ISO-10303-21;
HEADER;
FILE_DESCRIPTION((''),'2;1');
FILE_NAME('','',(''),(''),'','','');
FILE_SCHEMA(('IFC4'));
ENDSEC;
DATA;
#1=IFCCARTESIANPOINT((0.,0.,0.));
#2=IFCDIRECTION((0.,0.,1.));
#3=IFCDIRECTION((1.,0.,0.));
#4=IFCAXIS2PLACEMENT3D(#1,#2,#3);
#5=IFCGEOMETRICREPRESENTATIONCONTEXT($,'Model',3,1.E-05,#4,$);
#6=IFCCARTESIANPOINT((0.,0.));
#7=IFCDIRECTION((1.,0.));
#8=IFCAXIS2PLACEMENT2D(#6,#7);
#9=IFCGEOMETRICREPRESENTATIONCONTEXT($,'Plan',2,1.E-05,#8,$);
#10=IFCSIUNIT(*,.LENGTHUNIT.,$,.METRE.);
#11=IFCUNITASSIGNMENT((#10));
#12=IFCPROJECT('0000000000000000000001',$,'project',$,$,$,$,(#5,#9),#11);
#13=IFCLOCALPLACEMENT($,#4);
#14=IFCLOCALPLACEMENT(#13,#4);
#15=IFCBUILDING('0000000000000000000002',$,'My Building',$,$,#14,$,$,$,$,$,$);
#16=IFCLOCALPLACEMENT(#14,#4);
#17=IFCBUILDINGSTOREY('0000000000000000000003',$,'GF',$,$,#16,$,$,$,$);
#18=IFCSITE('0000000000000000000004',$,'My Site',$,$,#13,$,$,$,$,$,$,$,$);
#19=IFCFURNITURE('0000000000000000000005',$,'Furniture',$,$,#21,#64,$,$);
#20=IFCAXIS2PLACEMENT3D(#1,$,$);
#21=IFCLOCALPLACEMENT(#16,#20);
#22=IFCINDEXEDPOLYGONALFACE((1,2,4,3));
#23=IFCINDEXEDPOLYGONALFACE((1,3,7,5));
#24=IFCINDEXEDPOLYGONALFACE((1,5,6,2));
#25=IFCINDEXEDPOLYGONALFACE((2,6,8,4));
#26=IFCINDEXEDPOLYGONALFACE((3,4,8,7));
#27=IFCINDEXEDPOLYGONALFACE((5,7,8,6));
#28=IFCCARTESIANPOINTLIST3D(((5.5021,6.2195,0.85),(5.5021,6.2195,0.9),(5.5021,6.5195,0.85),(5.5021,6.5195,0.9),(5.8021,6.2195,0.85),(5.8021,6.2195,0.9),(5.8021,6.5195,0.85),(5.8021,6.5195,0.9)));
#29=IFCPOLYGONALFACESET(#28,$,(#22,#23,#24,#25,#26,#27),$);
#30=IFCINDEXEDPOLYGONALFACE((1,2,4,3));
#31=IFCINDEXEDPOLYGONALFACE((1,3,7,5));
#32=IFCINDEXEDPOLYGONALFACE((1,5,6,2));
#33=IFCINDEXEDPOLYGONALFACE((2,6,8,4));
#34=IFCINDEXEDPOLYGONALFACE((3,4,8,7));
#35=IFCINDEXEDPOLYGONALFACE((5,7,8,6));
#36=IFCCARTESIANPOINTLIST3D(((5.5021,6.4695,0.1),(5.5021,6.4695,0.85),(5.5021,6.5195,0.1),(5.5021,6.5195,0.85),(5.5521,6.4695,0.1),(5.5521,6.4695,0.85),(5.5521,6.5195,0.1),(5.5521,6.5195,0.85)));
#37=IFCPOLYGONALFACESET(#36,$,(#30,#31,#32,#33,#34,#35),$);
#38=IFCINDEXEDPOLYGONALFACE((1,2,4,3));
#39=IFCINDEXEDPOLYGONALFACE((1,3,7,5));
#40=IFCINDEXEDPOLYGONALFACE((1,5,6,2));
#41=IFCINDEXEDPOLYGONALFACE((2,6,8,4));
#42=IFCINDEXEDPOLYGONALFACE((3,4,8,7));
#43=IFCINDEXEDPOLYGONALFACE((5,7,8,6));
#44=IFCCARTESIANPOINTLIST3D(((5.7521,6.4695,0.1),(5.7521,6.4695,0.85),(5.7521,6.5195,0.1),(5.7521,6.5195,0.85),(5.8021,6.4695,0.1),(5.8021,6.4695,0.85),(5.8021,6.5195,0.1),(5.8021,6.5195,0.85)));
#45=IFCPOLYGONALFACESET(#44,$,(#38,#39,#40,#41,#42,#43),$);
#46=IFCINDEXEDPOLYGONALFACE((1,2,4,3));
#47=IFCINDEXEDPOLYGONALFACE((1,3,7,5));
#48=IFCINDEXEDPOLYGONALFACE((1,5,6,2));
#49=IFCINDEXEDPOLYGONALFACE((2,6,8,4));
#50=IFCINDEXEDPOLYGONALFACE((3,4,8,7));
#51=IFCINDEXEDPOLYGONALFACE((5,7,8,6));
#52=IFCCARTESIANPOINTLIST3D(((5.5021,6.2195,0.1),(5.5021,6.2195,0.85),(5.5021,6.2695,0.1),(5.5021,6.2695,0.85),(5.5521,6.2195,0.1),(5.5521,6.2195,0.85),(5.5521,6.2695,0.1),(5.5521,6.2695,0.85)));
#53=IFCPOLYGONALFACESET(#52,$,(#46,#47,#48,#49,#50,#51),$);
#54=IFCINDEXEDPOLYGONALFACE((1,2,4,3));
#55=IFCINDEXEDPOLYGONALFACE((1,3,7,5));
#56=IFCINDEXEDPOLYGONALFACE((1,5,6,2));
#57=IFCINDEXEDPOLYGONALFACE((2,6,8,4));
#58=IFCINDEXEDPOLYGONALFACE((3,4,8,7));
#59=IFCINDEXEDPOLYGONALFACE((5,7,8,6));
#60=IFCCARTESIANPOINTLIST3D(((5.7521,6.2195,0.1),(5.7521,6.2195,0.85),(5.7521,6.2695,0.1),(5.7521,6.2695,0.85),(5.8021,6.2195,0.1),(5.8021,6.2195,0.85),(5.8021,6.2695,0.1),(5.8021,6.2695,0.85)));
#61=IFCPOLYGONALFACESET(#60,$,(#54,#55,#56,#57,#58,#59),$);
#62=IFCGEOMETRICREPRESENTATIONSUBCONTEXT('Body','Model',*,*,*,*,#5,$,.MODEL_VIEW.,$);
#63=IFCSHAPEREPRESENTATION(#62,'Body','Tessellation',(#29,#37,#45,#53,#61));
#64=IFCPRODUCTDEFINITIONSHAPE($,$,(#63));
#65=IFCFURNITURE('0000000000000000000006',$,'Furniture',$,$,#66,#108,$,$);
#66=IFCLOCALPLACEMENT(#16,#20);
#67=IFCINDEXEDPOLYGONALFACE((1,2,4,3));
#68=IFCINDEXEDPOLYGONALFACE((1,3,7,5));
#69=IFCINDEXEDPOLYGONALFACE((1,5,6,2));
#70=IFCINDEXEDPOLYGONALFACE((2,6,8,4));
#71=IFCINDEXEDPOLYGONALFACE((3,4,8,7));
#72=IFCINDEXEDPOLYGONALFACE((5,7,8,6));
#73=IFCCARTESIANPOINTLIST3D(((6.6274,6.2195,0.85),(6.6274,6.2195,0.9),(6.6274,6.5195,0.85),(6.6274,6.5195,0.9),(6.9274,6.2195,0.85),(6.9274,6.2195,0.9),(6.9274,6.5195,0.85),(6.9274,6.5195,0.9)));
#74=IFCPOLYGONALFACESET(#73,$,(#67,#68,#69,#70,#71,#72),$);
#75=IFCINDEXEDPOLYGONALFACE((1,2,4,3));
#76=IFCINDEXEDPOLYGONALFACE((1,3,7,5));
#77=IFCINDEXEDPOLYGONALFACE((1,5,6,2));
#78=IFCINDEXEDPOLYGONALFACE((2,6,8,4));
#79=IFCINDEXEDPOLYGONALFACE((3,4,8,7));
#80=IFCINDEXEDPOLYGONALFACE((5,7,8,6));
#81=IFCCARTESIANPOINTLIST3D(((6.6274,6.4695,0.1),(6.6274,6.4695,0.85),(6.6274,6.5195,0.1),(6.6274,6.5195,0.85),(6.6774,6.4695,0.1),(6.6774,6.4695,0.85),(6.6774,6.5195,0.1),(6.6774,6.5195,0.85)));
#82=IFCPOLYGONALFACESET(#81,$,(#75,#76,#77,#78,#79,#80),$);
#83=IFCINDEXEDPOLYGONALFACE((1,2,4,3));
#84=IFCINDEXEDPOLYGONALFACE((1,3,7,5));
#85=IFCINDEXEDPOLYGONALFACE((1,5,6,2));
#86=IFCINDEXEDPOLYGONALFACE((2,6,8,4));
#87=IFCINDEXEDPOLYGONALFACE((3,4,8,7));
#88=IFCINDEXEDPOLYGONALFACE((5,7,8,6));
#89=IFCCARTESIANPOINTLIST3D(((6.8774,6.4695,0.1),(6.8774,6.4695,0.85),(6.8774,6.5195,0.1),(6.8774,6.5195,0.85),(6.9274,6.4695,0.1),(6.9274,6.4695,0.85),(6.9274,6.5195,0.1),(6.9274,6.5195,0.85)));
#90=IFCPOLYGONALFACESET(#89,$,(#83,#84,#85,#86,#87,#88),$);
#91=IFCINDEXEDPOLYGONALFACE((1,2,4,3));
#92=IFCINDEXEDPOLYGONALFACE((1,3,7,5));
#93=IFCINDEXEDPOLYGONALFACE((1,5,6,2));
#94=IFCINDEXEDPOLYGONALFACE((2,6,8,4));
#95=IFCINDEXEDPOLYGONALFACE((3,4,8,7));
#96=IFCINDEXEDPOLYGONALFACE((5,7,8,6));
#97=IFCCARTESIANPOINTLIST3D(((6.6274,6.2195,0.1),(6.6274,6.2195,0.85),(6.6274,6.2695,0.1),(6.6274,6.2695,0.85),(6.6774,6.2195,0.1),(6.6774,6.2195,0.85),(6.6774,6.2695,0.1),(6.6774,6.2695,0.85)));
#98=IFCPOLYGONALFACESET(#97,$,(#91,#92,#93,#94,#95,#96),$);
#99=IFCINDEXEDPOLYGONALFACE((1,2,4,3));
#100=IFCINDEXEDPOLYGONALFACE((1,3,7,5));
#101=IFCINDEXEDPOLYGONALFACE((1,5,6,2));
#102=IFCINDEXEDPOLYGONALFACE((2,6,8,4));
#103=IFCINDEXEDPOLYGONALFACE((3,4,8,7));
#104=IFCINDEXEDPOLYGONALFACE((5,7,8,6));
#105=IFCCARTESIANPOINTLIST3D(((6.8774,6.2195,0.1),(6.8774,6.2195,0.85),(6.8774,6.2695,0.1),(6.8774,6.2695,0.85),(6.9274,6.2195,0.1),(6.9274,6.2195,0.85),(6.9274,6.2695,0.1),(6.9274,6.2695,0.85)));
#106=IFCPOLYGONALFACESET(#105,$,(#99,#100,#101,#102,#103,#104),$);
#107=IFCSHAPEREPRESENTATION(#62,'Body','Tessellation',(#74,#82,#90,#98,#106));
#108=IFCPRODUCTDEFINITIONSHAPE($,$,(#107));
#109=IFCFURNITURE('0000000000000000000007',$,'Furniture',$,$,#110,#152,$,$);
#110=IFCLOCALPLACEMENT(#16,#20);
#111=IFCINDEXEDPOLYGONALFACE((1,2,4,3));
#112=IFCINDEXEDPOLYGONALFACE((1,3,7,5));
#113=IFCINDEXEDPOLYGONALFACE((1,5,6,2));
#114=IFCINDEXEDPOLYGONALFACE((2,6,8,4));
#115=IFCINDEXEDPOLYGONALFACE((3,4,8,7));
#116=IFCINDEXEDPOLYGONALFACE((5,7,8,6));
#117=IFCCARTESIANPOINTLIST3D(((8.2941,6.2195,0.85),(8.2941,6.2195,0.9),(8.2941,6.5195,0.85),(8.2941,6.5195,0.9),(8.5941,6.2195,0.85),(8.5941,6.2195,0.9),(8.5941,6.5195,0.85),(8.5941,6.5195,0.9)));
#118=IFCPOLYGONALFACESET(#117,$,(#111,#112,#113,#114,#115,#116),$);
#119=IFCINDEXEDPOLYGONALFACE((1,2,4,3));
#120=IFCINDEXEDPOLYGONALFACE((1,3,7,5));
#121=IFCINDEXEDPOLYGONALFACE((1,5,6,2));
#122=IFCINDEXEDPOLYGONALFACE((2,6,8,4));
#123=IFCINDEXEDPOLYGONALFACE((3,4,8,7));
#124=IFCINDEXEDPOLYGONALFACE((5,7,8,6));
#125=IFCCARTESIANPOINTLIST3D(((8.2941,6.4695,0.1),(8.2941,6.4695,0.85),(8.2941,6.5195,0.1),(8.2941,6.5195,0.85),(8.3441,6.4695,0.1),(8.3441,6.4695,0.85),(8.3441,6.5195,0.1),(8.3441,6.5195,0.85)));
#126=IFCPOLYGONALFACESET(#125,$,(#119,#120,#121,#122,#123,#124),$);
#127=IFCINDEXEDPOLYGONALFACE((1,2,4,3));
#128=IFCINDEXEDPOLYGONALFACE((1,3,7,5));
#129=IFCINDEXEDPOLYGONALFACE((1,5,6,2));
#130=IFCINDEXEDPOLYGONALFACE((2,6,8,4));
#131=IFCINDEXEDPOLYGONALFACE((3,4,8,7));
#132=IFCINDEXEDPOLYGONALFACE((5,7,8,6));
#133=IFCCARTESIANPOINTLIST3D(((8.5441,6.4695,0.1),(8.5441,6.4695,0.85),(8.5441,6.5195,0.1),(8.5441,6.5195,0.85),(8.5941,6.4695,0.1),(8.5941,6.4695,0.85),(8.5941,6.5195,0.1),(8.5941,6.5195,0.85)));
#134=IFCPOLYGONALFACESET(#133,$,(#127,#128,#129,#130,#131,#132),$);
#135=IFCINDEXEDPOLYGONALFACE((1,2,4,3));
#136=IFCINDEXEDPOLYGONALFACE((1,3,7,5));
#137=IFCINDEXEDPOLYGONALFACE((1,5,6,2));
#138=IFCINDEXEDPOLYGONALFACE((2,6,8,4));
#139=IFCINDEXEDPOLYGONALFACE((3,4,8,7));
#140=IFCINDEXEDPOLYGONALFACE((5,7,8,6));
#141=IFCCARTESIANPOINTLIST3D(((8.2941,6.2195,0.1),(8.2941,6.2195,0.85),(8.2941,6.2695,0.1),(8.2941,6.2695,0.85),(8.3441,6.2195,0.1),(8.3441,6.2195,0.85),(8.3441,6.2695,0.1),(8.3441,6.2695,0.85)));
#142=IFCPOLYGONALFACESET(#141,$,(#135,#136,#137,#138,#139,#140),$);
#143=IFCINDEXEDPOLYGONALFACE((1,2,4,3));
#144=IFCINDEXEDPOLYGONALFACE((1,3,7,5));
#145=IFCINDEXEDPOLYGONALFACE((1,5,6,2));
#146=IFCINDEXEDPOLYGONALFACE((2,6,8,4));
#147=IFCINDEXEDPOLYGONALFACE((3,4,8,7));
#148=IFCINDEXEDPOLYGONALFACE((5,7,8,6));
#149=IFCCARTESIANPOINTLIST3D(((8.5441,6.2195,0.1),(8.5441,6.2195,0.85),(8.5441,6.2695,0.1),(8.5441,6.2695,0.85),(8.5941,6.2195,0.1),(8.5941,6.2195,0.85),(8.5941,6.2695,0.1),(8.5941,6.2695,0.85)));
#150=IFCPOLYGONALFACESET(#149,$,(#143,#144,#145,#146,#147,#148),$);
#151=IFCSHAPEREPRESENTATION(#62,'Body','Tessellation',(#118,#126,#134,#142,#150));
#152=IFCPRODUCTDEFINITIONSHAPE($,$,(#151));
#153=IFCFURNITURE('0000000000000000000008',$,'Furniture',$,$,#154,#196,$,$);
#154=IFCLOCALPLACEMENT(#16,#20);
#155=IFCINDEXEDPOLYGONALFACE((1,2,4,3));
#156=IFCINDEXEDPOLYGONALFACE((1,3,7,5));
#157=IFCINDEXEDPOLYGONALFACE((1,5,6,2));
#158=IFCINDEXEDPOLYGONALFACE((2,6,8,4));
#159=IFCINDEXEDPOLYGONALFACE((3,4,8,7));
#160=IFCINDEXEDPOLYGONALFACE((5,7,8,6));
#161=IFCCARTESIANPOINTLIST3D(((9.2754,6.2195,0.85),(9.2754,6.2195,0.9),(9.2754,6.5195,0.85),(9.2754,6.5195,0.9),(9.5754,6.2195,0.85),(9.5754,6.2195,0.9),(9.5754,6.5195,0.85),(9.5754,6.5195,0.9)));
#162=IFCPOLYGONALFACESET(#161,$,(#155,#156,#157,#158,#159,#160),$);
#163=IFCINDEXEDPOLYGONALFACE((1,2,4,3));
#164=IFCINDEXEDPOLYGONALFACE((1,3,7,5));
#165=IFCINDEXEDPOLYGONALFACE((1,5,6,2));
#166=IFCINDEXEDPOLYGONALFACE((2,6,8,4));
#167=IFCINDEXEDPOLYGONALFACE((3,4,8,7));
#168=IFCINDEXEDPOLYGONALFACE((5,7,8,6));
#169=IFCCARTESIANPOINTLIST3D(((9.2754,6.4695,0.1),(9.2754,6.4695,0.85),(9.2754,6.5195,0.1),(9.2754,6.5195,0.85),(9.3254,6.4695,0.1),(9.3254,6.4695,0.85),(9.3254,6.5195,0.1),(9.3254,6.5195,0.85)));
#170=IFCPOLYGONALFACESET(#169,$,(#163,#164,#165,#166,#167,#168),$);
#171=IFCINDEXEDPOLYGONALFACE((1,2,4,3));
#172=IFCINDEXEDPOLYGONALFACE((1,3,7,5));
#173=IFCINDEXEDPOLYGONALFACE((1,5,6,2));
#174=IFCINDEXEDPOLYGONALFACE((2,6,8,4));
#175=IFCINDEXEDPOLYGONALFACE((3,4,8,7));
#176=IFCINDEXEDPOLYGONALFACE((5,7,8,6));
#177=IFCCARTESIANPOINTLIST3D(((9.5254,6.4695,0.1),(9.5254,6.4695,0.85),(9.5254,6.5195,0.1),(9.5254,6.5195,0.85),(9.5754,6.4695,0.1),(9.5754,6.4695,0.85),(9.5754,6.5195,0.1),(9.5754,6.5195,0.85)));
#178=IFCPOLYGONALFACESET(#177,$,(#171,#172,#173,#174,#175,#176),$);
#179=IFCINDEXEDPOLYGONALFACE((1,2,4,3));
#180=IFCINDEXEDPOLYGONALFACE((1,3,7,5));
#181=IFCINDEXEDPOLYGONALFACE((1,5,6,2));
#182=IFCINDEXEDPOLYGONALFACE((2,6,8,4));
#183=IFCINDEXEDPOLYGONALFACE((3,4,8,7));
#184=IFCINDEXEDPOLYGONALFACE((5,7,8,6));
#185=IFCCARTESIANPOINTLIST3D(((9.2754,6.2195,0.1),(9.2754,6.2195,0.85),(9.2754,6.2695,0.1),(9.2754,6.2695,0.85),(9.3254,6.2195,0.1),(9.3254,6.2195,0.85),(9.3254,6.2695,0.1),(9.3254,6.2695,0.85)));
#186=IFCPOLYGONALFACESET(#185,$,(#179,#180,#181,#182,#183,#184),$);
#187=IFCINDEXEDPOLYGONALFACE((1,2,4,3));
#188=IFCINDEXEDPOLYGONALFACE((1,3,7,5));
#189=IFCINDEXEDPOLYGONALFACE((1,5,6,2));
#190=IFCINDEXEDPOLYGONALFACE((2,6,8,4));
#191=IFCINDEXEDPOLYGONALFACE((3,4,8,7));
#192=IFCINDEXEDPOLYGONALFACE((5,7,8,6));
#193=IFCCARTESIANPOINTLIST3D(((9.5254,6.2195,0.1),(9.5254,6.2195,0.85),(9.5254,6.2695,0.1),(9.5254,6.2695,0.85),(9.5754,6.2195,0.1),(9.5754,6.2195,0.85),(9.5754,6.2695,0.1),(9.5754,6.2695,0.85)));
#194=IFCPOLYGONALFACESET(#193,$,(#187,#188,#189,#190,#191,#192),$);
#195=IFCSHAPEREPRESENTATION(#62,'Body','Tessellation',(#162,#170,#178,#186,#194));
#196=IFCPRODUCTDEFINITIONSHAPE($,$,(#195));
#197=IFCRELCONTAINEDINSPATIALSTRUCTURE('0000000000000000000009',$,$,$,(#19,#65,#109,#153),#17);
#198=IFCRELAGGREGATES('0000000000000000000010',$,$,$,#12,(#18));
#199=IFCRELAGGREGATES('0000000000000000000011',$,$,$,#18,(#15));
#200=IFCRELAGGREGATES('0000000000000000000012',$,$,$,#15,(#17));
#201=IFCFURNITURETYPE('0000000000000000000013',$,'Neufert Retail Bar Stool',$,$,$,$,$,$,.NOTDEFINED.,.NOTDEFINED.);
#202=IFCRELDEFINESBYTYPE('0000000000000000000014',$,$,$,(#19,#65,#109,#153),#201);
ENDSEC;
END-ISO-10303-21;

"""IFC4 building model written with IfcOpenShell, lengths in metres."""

from ifc_helpers import new_model, entity, si_unit, frame, origin_with_axes, origin_2d_with_axis, place, context, subcontext, project, spatial, line, indexed_curve, outline, extrude, shape, source, transform, mapped, type_object, type_shapes, element, save


model = new_model("IFC4")

# Units and contexts
model_context = context("Model", 3, precision=1e-05, world=origin_with_axes())
plan_context = context("Plan", 2, precision=1e-05, world=origin_2d_with_axis())
body_context_1 = subcontext(model_context, "Body", "Model", "MODEL_VIEW")
body_context_2 = subcontext(plan_context, "Body", "Plan", "PLAN_VIEW")
ifc_project = project(units=[si_unit("LENGTHUNIT", "METRE")], contexts=[model_context, plan_context])

# Site, building, storey
site_placement = place(None, origin_with_axes())
site = spatial("IfcSite", under=ifc_project, at=site_placement, Name="My Site")
building_placement = place(site_placement, origin_with_axes())
building = spatial("IfcBuilding", under=site, at=building_placement, Name="My Building")
storey_placement = place(building_placement, origin_with_axes())
storey = spatial("IfcBuildingStorey", under=building, at=storey_placement, Name="GF")

# Furniture
furniture_type_1 = type_object("IfcFurnitureType", Name="Neufert Retail Bar Stool", AssemblyPlace="NOTDEFINED", PredefinedType="NOTDEFINED")
shared_shape_1 = source(origin_with_axes(), body_context_1, "Body", "SweptSolid", [
    extrude(outline(indexed_curve([(-0.15, 0.0), (0.15, 0.0), (0.15, -0.3), (-0.15, -0.3)], segments=[line(1, 2, 3, 4, 1)])), frame((0.0, 0.0, 0.8), z_axis=(0.0, 0.0, 1.0), x_axis=(1.0, 0.0, 0.0)), (0.0, 0.0, -1.0), 0.05),
    extrude(outline(indexed_curve([(-0.15, 0.0), (-0.1, 0.0), (-0.1, -0.05), (-0.15, -0.05)], segments=[line(1, 2, 3, 4, 1)])), origin_with_axes(), (0.0, 0.0, 1.0), 0.75),
    extrude(outline(indexed_curve([(0.15, 0.0), (0.1, 0.0), (0.1, -0.05), (0.15, -0.05)], segments=[line(1, 2, 3, 4, 1)])), origin_with_axes(), (0.0, 0.0, 1.0), 0.75),
    extrude(outline(indexed_curve([(-0.15, -0.3), (-0.1, -0.3), (-0.1, -0.25), (-0.15, -0.25)], segments=[line(1, 2, 3, 4, 1)])), origin_with_axes(), (0.0, 0.0, 1.0), 0.75),
    extrude(outline(indexed_curve([(0.15, -0.3), (0.1, -0.3), (0.1, -0.25), (0.15, -0.25)], segments=[line(1, 2, 3, 4, 1)])), origin_with_axes(), (0.0, 0.0, 1.0), 0.75),
])
shared_shape_2 = source(origin_with_axes(), body_context_2, "Body", "Curve2D", [
    entity("IfcIndexedPolyCurve", entity("IfcCartesianPointList2D", [[-0.15, -0.3], [0.15, -0.3]])),
    entity("IfcIndexedPolyCurve", entity("IfcCartesianPointList2D", [[-0.15, -0.3], [-0.15, -0.15], [-0.1061, -0.0439], [0.0, 0.0], [0.1061, -0.0439], [0.15, -0.15], [0.15, -0.3]]), [entity("IfcLineIndex", [1, 2]), entity("IfcArcIndex", [2, 3, 4]), entity("IfcArcIndex", [4, 5, 6]), entity("IfcLineIndex", [6, 7])]),
    entity("IfcIndexedPolyCurve", entity("IfcCartesianPointList2D", [[-0.12, -0.3], [-0.12, -0.15], [-0.0849, -0.0651], [0.0, -0.03], [0.0849, -0.0651], [0.12, -0.15], [0.12, -0.3]]), [entity("IfcLineIndex", [1, 2]), entity("IfcArcIndex", [2, 3, 4]), entity("IfcArcIndex", [4, 5, 6]), entity("IfcLineIndex", [6, 7])]),
])
type_shapes(furniture_type_1, [shared_shape_1, shared_shape_2])
for number, where, z_axis, x_axis, name in (
    (1, (5.6521, 6.5195, 0.1), (0.0, 0.0, 1.0), (1.0, 0.0, 0.0), "Furniture"),
    (2, (6.7774, 6.5195, 0.1), (0.0, 0.0, 1.0), (1.0, 0.0, 0.0), "Furniture"),
    (3, (8.4441, 6.5195, 0.1), (0.0, 0.0, 1.0), (1.0, 0.0, 0.0), "Furniture"),
    (4, (9.4254, 6.5195, 0.1), (0.0, 0.0, 1.0), (1.0, 0.0, 0.0), "Furniture"),
):
    element("IfcFurniture", number, at=place(storey_placement, frame(where, z_axis=z_axis, x_axis=x_axis)), inside=storey, type_object=furniture_type_1, Name=name, shapes=[
        shape(body_context_1, "Body", "MappedRepresentation", [mapped(shared_shape_1, transform((0.0, 0.0, 0.0), x_axis=(1.0, 0.0, 0.0), y_axis=(0.0, 1.0, 0.0), z_axis=(0.0, 0.0, 1.0), scale=1.0))]),
        shape(body_context_2, "Body", "MappedRepresentation", [mapped(shared_shape_2, transform((0.0, 0.0, 0.0), x_axis=(1.0, 0.0, 0.0), y_axis=(0.0, 1.0, 0.0), z_axis=(0.0, 0.0, 1.0), scale=1.0))]),
    ])

save(model, "model.ifc")
